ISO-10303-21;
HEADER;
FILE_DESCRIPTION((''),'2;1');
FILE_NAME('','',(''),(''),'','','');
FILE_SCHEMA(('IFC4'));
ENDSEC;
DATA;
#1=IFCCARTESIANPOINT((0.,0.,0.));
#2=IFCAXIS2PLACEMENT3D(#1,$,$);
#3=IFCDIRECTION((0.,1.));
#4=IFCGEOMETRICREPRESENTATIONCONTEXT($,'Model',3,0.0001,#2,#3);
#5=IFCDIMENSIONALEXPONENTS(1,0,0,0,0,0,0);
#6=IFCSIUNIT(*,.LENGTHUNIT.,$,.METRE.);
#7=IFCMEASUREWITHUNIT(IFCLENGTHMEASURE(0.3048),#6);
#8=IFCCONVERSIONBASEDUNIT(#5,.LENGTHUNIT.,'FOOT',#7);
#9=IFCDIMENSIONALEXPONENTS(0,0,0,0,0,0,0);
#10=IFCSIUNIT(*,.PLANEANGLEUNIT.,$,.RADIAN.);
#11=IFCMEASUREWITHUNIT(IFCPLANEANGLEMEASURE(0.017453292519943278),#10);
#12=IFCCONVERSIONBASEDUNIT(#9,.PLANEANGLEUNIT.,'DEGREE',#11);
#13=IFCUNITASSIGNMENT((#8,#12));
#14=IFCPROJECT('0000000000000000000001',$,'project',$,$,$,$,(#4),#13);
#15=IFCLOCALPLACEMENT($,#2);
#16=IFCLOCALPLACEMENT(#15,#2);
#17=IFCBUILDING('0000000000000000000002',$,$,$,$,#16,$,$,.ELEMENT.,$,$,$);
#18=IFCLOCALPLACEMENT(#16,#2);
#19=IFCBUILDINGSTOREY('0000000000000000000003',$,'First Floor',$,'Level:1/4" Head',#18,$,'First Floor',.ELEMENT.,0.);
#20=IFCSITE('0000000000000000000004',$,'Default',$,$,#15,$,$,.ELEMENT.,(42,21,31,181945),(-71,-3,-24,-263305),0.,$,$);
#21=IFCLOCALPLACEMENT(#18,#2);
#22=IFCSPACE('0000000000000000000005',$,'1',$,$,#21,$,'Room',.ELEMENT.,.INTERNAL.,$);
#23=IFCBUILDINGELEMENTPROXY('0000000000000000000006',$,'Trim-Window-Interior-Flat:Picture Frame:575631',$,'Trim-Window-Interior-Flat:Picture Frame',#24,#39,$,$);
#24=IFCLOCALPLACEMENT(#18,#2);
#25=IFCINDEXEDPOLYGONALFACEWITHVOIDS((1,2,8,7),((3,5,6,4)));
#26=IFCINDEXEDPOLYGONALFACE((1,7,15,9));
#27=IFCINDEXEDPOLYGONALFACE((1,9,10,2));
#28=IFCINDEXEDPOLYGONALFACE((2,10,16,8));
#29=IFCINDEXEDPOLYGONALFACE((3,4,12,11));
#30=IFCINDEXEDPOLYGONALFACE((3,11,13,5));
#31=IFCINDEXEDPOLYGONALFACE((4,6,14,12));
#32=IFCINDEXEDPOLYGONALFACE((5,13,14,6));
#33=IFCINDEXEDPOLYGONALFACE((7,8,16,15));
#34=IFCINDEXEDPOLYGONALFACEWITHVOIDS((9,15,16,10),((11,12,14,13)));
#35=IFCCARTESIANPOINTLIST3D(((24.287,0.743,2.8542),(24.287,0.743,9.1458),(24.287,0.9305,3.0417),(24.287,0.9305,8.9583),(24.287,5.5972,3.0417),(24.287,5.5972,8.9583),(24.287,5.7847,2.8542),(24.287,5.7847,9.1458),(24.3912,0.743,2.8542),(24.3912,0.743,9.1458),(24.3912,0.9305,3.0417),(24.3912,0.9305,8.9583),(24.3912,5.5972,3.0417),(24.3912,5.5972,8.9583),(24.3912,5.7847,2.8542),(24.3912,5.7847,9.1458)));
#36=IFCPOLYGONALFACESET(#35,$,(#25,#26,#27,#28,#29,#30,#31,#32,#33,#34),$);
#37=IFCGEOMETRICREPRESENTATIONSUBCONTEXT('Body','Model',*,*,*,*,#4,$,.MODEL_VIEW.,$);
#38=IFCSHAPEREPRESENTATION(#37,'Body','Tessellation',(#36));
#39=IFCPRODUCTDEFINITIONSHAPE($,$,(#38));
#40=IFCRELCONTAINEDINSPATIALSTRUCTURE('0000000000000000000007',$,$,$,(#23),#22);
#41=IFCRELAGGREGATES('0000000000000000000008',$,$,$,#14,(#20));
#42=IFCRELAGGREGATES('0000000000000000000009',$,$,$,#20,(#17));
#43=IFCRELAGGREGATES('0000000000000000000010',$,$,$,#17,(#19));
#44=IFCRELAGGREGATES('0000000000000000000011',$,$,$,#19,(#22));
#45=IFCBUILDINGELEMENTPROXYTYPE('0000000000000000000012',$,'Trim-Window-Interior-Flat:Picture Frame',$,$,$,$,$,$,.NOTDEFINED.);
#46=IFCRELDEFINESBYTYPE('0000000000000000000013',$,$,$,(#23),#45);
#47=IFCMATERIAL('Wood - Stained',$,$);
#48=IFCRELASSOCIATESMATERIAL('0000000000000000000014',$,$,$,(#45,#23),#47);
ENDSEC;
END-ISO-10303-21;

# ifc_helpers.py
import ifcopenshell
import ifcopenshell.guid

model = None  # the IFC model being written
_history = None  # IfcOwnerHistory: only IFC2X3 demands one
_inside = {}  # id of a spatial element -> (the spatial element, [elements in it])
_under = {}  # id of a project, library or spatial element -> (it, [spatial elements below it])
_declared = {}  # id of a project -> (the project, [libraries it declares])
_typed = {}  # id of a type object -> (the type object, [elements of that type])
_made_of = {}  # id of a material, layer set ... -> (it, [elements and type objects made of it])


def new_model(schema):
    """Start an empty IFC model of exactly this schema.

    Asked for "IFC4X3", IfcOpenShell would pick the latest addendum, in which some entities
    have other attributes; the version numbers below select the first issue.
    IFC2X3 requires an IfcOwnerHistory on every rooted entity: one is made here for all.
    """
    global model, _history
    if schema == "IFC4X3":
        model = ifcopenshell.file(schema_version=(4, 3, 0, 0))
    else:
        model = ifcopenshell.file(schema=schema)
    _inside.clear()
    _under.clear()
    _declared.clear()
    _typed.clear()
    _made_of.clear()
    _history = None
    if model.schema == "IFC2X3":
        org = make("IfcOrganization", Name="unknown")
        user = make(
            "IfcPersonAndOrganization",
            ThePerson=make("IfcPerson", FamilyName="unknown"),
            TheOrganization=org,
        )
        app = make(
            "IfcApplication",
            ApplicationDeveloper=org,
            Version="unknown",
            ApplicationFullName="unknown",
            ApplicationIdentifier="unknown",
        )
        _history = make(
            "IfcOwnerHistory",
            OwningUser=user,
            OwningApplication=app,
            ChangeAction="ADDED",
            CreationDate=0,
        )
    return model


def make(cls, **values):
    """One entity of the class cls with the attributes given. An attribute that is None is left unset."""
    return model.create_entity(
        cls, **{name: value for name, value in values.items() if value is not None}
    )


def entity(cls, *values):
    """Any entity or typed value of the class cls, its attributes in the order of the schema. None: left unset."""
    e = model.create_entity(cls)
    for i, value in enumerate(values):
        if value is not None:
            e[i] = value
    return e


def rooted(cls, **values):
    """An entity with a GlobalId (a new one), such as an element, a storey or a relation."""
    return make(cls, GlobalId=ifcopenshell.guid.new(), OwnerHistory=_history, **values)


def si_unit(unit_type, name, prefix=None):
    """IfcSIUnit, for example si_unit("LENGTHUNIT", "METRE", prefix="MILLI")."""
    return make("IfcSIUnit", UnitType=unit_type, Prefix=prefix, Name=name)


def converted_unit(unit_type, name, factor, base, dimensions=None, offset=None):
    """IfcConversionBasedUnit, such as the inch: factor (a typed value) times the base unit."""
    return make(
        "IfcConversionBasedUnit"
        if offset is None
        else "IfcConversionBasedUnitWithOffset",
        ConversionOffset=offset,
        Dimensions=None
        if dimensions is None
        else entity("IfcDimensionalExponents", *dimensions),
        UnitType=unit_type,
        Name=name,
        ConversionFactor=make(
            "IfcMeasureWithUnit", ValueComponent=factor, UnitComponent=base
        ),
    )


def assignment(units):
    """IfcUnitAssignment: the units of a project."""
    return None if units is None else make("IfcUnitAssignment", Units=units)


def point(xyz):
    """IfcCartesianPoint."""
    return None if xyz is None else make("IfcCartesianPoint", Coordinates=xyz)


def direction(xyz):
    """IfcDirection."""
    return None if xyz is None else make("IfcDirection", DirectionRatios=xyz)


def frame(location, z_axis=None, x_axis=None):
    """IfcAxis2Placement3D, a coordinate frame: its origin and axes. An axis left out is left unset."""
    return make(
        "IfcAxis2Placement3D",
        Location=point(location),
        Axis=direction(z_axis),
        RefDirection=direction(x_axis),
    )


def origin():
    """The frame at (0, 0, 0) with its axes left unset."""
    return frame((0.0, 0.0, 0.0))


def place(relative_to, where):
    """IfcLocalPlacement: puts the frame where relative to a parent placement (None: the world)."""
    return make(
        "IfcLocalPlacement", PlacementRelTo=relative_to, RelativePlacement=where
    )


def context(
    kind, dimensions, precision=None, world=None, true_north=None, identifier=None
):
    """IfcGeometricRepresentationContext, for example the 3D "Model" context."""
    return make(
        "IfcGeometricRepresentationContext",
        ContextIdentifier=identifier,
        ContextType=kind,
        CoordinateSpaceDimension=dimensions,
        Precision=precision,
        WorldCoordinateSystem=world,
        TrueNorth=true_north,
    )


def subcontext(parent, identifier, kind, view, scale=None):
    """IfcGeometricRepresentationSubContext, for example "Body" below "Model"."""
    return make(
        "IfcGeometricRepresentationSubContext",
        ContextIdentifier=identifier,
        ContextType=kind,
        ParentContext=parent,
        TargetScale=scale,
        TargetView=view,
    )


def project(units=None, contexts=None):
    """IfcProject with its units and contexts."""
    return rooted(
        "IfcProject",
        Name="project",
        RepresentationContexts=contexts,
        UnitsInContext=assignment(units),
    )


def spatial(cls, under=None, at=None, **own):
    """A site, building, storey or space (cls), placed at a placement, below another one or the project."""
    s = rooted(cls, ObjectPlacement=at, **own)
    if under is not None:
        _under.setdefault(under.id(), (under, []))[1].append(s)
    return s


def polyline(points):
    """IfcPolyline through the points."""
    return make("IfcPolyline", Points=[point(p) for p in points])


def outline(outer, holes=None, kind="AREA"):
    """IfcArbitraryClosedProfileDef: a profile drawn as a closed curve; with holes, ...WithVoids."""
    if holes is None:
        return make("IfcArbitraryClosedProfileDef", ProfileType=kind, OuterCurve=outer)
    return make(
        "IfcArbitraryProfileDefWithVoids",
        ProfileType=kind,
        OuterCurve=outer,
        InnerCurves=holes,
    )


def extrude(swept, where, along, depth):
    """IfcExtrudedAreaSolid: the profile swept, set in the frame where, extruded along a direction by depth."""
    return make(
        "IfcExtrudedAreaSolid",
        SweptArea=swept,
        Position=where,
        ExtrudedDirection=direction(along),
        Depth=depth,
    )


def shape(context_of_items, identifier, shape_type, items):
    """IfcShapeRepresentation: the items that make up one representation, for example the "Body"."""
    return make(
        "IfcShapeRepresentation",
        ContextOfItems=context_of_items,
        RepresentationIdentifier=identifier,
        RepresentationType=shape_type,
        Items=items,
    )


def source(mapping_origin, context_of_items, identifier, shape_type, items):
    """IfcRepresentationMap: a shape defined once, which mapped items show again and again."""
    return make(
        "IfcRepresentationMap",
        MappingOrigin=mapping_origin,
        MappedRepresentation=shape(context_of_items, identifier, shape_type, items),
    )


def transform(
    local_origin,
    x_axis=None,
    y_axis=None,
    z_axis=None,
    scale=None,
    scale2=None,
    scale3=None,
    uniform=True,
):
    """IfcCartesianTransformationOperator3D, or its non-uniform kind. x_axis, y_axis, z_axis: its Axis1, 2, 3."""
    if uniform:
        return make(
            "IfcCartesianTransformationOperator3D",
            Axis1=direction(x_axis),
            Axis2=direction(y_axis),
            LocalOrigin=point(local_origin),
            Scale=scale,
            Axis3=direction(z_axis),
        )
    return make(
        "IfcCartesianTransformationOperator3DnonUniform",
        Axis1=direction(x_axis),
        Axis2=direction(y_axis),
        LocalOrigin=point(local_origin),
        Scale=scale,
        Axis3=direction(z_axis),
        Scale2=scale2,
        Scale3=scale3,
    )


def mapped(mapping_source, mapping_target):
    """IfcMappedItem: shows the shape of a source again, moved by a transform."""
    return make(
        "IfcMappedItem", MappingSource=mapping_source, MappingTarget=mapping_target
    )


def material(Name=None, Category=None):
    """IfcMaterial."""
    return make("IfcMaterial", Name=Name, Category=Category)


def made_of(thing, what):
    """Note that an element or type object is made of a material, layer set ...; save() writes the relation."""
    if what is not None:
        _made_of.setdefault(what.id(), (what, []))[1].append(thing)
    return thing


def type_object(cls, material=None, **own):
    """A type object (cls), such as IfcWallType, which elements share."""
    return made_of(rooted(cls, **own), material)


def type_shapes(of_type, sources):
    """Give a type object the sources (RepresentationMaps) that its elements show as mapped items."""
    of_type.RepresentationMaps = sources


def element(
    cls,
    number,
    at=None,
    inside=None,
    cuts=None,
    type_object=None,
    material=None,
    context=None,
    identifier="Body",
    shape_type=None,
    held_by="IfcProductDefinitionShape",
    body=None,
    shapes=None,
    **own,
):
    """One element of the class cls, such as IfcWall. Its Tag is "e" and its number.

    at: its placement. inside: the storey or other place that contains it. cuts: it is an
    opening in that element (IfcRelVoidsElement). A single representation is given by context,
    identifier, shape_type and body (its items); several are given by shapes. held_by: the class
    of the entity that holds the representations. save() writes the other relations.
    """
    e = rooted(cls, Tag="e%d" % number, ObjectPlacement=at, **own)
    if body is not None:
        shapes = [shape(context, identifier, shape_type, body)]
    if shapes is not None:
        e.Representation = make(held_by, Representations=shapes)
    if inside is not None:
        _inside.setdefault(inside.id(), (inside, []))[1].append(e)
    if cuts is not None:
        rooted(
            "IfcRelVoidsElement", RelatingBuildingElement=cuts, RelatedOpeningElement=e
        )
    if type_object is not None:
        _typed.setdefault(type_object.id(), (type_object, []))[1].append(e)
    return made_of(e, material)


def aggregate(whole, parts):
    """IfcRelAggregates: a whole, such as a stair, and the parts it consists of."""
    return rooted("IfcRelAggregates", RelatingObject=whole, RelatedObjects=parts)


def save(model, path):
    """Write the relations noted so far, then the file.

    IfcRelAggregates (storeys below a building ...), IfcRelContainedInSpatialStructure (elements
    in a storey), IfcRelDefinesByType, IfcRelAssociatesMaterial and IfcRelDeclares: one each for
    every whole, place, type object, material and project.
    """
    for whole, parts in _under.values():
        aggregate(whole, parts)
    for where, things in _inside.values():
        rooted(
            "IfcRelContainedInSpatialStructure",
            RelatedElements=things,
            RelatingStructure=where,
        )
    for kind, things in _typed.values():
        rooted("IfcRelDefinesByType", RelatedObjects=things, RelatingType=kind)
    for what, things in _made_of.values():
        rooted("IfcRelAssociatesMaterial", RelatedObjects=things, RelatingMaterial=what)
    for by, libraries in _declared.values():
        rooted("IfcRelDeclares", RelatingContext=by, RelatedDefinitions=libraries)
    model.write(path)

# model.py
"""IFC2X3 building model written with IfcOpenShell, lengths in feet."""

from ifc_helpers import new_model, entity, si_unit, converted_unit, direction, frame, origin, place, context, subcontext, project, spatial, polyline, outline, extrude, source, transform, mapped, material, type_object, type_shapes, element, save


model = new_model("IFC2X3")

# Units and contexts
model_context = context("Model", 3, precision=0.0001, world=origin(), true_north=direction((0.0, 1.0)))
body_context = subcontext(model_context, "Body", "Model", "MODEL_VIEW")
ifc_project = project(units=[converted_unit("LENGTHUNIT", "FOOT", entity("IfcLengthMeasure", 0.3048), si_unit("LENGTHUNIT", "METRE"), dimensions=[1, 0, 0, 0, 0, 0, 0]), converted_unit("PLANEANGLEUNIT", "DEGREE", entity("IfcPlaneAngleMeasure", 0.017453292519943278), si_unit("PLANEANGLEUNIT", "RADIAN"), dimensions=[0, 0, 0, 0, 0, 0, 0])], contexts=[model_context])

# Site, building, storey
site_placement = place(None, origin())
site = spatial("IfcSite", under=ifc_project, at=site_placement, Name="Default", CompositionType="ELEMENT", RefLatitude=(42, 21, 31, 181945), RefLongitude=(-71, -3, -24, -263305), RefElevation=0.0)
building_placement = place(site_placement, origin())
building = spatial("IfcBuilding", under=site, at=building_placement, CompositionType="ELEMENT")
storey_placement = place(building_placement, origin())
storey = spatial("IfcBuildingStorey", under=building, at=storey_placement, Name="First Floor", ObjectType="Level:1/4\" Head", LongName="First Floor", CompositionType="ELEMENT", Elevation=0.0)

# Shared definitions
space_placement = place(storey_placement, origin())
space = spatial("IfcSpace", under=storey, at=space_placement, Name="1", LongName="Room", CompositionType="ELEMENT", InteriorOrExteriorSpace="INTERNAL")

# Building element proxy
ifc_material_1 = material(Name="Wood - Stained")
building_element_proxy_type_1 = type_object("IfcBuildingElementProxyType", Name="Trim-Window-Interior-Flat:Picture Frame", PredefinedType="NOTDEFINED", material=ifc_material_1)
shared_shape_1 = source(origin(), body_context, "Body", "SweptSolid", [
    extrude(outline(polyline([(-2.5208, -3.1458), (2.5208, -3.1458), (2.5208, 3.1458), (-2.5208, 3.1458), (-2.5208, -3.1458)]), holes=[polyline([(-2.3333, -2.9583), (-2.3333, 2.9583), (2.3333, 2.9583), (2.3333, -2.9583), (-2.3333, -2.9583)])]), frame((0.0, -3.0, 0.0), z_axis=(0.0, 0.0, 1.0), x_axis=(-1.0, 0.0, 0.0)), (0.0, 0.0, 1.0), 0.1042),
])
type_shapes(building_element_proxy_type_1, [shared_shape_1])
proxy_1_placement = place(space_placement, frame((24.3912, 3.2639, 9.0), z_axis=(-1.0, 0.0, 0.0), x_axis=(0.0, -1.0, 0.0)))
element("IfcBuildingElementProxy", 1, at=proxy_1_placement, inside=space, type_object=building_element_proxy_type_1, material=ifc_material_1, Name="Trim-Window-Interior-Flat:Picture Frame:575631", ObjectType="Trim-Window-Interior-Flat:Picture Frame", context=body_context, shape_type="MappedRepresentation", body=[
    mapped(shared_shape_1, transform((0.0, 0.0, 0.0), scale=1.0)),
])

save(model, "model.ifc")
